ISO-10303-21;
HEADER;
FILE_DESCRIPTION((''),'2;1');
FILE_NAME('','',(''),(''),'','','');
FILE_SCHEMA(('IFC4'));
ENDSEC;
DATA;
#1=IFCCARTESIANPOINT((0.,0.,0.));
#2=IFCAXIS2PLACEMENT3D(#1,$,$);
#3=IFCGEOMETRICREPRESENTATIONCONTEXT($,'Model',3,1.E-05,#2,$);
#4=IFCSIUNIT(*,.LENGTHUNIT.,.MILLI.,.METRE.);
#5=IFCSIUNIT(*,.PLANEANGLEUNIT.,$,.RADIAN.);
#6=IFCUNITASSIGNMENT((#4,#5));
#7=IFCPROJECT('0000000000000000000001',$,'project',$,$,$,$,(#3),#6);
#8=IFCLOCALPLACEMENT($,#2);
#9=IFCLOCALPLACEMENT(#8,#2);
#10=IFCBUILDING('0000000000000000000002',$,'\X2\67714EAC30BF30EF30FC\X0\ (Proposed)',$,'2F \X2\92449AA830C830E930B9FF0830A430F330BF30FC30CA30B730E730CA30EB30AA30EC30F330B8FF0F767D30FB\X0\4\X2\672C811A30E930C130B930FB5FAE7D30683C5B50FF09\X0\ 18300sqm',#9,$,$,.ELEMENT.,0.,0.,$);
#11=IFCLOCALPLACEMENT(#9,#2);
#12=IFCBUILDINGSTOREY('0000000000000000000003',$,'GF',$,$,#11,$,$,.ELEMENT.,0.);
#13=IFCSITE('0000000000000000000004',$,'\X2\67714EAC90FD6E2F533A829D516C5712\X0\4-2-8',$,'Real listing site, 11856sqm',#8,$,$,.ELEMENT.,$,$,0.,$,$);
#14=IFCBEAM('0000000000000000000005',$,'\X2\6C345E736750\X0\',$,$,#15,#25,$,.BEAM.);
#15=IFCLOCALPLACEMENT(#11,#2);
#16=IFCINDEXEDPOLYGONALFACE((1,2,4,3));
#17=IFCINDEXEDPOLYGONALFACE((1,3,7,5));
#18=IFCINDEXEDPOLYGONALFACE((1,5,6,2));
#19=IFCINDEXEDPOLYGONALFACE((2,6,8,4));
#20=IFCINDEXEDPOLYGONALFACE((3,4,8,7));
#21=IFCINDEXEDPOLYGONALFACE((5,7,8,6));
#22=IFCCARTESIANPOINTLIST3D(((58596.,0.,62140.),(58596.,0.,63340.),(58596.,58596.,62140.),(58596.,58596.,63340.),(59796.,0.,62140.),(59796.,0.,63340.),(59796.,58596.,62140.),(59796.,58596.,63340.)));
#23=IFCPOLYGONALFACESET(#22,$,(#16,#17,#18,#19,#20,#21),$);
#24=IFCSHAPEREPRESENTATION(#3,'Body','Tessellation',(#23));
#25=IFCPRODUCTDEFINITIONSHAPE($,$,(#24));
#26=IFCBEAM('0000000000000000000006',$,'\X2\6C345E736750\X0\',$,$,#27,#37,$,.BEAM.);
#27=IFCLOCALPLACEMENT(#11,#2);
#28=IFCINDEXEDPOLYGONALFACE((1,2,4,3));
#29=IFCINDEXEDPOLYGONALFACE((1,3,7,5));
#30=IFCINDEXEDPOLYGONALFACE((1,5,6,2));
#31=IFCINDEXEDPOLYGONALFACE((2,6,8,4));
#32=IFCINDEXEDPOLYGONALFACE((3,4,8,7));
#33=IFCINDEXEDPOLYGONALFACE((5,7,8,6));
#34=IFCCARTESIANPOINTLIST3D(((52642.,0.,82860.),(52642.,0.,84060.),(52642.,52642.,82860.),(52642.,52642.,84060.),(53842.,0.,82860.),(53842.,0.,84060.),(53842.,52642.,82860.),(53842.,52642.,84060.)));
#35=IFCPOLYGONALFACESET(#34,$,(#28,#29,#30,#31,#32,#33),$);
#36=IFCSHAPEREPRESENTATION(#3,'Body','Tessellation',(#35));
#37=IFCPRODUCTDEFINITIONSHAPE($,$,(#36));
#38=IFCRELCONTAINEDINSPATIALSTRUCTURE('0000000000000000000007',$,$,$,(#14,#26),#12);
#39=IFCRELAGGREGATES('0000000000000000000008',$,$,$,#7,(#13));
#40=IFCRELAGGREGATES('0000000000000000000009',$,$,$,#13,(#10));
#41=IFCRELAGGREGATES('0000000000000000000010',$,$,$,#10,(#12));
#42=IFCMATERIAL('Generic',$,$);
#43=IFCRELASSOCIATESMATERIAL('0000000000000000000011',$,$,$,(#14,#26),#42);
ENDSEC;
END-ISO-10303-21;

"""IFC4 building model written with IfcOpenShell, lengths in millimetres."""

from ifc_helpers import new_model, si_unit, frame, frame_2d, origin, place, context, project, spatial, rectangle, extrude, material, element, save


model = new_model("IFC4")

# Units and contexts
model_context = context("Model", 3, precision=1e-05, world=origin())
ifc_project = project(units=[si_unit("LENGTHUNIT", "METRE", prefix="MILLI"), si_unit("PLANEANGLEUNIT", "RADIAN")], contexts=[model_context])

# Site, building, storey
site_placement = place(None, origin())
site = spatial("IfcSite", under=ifc_project, at=site_placement, Name="東京都港区芝公園4-2-8", ObjectType="Real listing site, 11856sqm", CompositionType="ELEMENT", RefElevation=0.0)
building_placement = place(site_placement, origin())
building = spatial("IfcBuilding", under=site, at=building_placement, Name="東京タワー (Proposed)", ObjectType="2F 鉄骨トラス（インターナショナルオレンジ／白・4本脚ラチス・微細格子） 18300sqm", CompositionType="ELEMENT", ElevationOfRefHeight=0.0, ElevationOfTerrain=0.0)
storey_placement = place(building_placement, origin())
storey = spatial("IfcBuildingStorey", under=building, at=storey_placement, Name="GF", CompositionType="ELEMENT", Elevation=0.0)

# Shared definitions
ifc_material = material(Name="Generic")

# Beams
beam_1_placement = place(storey_placement, frame((29298.0, 0.0, 31070.0)))
element("IfcBeam", 1, at=beam_1_placement, inside=storey, material=ifc_material, Name="水平材", PredefinedType="BEAM", context=model_context, shape_type="SweptSolid", body=[
    extrude(rectangle(XDim=1200.0, YDim=58596.0, at=frame_2d((600.0, 29298.0))), frame((29298.0, 0.0, 31070.0)), (0.0, 0.0, 1.0), 1200.0),
])
beam_2_placement = place(storey_placement, frame((26321.0, 0.0, 41430.0)))
element("IfcBeam", 2, at=beam_2_placement, inside=storey, material=ifc_material, Name="水平材", PredefinedType="BEAM", context=model_context, shape_type="SweptSolid", body=[
    extrude(rectangle(XDim=1200.0, YDim=52642.0, at=frame_2d((600.0, 26321.0))), frame((26321.0, 0.0, 41430.0)), (0.0, 0.0, 1.0), 1200.0),
])

save(model, "model.ifc")
